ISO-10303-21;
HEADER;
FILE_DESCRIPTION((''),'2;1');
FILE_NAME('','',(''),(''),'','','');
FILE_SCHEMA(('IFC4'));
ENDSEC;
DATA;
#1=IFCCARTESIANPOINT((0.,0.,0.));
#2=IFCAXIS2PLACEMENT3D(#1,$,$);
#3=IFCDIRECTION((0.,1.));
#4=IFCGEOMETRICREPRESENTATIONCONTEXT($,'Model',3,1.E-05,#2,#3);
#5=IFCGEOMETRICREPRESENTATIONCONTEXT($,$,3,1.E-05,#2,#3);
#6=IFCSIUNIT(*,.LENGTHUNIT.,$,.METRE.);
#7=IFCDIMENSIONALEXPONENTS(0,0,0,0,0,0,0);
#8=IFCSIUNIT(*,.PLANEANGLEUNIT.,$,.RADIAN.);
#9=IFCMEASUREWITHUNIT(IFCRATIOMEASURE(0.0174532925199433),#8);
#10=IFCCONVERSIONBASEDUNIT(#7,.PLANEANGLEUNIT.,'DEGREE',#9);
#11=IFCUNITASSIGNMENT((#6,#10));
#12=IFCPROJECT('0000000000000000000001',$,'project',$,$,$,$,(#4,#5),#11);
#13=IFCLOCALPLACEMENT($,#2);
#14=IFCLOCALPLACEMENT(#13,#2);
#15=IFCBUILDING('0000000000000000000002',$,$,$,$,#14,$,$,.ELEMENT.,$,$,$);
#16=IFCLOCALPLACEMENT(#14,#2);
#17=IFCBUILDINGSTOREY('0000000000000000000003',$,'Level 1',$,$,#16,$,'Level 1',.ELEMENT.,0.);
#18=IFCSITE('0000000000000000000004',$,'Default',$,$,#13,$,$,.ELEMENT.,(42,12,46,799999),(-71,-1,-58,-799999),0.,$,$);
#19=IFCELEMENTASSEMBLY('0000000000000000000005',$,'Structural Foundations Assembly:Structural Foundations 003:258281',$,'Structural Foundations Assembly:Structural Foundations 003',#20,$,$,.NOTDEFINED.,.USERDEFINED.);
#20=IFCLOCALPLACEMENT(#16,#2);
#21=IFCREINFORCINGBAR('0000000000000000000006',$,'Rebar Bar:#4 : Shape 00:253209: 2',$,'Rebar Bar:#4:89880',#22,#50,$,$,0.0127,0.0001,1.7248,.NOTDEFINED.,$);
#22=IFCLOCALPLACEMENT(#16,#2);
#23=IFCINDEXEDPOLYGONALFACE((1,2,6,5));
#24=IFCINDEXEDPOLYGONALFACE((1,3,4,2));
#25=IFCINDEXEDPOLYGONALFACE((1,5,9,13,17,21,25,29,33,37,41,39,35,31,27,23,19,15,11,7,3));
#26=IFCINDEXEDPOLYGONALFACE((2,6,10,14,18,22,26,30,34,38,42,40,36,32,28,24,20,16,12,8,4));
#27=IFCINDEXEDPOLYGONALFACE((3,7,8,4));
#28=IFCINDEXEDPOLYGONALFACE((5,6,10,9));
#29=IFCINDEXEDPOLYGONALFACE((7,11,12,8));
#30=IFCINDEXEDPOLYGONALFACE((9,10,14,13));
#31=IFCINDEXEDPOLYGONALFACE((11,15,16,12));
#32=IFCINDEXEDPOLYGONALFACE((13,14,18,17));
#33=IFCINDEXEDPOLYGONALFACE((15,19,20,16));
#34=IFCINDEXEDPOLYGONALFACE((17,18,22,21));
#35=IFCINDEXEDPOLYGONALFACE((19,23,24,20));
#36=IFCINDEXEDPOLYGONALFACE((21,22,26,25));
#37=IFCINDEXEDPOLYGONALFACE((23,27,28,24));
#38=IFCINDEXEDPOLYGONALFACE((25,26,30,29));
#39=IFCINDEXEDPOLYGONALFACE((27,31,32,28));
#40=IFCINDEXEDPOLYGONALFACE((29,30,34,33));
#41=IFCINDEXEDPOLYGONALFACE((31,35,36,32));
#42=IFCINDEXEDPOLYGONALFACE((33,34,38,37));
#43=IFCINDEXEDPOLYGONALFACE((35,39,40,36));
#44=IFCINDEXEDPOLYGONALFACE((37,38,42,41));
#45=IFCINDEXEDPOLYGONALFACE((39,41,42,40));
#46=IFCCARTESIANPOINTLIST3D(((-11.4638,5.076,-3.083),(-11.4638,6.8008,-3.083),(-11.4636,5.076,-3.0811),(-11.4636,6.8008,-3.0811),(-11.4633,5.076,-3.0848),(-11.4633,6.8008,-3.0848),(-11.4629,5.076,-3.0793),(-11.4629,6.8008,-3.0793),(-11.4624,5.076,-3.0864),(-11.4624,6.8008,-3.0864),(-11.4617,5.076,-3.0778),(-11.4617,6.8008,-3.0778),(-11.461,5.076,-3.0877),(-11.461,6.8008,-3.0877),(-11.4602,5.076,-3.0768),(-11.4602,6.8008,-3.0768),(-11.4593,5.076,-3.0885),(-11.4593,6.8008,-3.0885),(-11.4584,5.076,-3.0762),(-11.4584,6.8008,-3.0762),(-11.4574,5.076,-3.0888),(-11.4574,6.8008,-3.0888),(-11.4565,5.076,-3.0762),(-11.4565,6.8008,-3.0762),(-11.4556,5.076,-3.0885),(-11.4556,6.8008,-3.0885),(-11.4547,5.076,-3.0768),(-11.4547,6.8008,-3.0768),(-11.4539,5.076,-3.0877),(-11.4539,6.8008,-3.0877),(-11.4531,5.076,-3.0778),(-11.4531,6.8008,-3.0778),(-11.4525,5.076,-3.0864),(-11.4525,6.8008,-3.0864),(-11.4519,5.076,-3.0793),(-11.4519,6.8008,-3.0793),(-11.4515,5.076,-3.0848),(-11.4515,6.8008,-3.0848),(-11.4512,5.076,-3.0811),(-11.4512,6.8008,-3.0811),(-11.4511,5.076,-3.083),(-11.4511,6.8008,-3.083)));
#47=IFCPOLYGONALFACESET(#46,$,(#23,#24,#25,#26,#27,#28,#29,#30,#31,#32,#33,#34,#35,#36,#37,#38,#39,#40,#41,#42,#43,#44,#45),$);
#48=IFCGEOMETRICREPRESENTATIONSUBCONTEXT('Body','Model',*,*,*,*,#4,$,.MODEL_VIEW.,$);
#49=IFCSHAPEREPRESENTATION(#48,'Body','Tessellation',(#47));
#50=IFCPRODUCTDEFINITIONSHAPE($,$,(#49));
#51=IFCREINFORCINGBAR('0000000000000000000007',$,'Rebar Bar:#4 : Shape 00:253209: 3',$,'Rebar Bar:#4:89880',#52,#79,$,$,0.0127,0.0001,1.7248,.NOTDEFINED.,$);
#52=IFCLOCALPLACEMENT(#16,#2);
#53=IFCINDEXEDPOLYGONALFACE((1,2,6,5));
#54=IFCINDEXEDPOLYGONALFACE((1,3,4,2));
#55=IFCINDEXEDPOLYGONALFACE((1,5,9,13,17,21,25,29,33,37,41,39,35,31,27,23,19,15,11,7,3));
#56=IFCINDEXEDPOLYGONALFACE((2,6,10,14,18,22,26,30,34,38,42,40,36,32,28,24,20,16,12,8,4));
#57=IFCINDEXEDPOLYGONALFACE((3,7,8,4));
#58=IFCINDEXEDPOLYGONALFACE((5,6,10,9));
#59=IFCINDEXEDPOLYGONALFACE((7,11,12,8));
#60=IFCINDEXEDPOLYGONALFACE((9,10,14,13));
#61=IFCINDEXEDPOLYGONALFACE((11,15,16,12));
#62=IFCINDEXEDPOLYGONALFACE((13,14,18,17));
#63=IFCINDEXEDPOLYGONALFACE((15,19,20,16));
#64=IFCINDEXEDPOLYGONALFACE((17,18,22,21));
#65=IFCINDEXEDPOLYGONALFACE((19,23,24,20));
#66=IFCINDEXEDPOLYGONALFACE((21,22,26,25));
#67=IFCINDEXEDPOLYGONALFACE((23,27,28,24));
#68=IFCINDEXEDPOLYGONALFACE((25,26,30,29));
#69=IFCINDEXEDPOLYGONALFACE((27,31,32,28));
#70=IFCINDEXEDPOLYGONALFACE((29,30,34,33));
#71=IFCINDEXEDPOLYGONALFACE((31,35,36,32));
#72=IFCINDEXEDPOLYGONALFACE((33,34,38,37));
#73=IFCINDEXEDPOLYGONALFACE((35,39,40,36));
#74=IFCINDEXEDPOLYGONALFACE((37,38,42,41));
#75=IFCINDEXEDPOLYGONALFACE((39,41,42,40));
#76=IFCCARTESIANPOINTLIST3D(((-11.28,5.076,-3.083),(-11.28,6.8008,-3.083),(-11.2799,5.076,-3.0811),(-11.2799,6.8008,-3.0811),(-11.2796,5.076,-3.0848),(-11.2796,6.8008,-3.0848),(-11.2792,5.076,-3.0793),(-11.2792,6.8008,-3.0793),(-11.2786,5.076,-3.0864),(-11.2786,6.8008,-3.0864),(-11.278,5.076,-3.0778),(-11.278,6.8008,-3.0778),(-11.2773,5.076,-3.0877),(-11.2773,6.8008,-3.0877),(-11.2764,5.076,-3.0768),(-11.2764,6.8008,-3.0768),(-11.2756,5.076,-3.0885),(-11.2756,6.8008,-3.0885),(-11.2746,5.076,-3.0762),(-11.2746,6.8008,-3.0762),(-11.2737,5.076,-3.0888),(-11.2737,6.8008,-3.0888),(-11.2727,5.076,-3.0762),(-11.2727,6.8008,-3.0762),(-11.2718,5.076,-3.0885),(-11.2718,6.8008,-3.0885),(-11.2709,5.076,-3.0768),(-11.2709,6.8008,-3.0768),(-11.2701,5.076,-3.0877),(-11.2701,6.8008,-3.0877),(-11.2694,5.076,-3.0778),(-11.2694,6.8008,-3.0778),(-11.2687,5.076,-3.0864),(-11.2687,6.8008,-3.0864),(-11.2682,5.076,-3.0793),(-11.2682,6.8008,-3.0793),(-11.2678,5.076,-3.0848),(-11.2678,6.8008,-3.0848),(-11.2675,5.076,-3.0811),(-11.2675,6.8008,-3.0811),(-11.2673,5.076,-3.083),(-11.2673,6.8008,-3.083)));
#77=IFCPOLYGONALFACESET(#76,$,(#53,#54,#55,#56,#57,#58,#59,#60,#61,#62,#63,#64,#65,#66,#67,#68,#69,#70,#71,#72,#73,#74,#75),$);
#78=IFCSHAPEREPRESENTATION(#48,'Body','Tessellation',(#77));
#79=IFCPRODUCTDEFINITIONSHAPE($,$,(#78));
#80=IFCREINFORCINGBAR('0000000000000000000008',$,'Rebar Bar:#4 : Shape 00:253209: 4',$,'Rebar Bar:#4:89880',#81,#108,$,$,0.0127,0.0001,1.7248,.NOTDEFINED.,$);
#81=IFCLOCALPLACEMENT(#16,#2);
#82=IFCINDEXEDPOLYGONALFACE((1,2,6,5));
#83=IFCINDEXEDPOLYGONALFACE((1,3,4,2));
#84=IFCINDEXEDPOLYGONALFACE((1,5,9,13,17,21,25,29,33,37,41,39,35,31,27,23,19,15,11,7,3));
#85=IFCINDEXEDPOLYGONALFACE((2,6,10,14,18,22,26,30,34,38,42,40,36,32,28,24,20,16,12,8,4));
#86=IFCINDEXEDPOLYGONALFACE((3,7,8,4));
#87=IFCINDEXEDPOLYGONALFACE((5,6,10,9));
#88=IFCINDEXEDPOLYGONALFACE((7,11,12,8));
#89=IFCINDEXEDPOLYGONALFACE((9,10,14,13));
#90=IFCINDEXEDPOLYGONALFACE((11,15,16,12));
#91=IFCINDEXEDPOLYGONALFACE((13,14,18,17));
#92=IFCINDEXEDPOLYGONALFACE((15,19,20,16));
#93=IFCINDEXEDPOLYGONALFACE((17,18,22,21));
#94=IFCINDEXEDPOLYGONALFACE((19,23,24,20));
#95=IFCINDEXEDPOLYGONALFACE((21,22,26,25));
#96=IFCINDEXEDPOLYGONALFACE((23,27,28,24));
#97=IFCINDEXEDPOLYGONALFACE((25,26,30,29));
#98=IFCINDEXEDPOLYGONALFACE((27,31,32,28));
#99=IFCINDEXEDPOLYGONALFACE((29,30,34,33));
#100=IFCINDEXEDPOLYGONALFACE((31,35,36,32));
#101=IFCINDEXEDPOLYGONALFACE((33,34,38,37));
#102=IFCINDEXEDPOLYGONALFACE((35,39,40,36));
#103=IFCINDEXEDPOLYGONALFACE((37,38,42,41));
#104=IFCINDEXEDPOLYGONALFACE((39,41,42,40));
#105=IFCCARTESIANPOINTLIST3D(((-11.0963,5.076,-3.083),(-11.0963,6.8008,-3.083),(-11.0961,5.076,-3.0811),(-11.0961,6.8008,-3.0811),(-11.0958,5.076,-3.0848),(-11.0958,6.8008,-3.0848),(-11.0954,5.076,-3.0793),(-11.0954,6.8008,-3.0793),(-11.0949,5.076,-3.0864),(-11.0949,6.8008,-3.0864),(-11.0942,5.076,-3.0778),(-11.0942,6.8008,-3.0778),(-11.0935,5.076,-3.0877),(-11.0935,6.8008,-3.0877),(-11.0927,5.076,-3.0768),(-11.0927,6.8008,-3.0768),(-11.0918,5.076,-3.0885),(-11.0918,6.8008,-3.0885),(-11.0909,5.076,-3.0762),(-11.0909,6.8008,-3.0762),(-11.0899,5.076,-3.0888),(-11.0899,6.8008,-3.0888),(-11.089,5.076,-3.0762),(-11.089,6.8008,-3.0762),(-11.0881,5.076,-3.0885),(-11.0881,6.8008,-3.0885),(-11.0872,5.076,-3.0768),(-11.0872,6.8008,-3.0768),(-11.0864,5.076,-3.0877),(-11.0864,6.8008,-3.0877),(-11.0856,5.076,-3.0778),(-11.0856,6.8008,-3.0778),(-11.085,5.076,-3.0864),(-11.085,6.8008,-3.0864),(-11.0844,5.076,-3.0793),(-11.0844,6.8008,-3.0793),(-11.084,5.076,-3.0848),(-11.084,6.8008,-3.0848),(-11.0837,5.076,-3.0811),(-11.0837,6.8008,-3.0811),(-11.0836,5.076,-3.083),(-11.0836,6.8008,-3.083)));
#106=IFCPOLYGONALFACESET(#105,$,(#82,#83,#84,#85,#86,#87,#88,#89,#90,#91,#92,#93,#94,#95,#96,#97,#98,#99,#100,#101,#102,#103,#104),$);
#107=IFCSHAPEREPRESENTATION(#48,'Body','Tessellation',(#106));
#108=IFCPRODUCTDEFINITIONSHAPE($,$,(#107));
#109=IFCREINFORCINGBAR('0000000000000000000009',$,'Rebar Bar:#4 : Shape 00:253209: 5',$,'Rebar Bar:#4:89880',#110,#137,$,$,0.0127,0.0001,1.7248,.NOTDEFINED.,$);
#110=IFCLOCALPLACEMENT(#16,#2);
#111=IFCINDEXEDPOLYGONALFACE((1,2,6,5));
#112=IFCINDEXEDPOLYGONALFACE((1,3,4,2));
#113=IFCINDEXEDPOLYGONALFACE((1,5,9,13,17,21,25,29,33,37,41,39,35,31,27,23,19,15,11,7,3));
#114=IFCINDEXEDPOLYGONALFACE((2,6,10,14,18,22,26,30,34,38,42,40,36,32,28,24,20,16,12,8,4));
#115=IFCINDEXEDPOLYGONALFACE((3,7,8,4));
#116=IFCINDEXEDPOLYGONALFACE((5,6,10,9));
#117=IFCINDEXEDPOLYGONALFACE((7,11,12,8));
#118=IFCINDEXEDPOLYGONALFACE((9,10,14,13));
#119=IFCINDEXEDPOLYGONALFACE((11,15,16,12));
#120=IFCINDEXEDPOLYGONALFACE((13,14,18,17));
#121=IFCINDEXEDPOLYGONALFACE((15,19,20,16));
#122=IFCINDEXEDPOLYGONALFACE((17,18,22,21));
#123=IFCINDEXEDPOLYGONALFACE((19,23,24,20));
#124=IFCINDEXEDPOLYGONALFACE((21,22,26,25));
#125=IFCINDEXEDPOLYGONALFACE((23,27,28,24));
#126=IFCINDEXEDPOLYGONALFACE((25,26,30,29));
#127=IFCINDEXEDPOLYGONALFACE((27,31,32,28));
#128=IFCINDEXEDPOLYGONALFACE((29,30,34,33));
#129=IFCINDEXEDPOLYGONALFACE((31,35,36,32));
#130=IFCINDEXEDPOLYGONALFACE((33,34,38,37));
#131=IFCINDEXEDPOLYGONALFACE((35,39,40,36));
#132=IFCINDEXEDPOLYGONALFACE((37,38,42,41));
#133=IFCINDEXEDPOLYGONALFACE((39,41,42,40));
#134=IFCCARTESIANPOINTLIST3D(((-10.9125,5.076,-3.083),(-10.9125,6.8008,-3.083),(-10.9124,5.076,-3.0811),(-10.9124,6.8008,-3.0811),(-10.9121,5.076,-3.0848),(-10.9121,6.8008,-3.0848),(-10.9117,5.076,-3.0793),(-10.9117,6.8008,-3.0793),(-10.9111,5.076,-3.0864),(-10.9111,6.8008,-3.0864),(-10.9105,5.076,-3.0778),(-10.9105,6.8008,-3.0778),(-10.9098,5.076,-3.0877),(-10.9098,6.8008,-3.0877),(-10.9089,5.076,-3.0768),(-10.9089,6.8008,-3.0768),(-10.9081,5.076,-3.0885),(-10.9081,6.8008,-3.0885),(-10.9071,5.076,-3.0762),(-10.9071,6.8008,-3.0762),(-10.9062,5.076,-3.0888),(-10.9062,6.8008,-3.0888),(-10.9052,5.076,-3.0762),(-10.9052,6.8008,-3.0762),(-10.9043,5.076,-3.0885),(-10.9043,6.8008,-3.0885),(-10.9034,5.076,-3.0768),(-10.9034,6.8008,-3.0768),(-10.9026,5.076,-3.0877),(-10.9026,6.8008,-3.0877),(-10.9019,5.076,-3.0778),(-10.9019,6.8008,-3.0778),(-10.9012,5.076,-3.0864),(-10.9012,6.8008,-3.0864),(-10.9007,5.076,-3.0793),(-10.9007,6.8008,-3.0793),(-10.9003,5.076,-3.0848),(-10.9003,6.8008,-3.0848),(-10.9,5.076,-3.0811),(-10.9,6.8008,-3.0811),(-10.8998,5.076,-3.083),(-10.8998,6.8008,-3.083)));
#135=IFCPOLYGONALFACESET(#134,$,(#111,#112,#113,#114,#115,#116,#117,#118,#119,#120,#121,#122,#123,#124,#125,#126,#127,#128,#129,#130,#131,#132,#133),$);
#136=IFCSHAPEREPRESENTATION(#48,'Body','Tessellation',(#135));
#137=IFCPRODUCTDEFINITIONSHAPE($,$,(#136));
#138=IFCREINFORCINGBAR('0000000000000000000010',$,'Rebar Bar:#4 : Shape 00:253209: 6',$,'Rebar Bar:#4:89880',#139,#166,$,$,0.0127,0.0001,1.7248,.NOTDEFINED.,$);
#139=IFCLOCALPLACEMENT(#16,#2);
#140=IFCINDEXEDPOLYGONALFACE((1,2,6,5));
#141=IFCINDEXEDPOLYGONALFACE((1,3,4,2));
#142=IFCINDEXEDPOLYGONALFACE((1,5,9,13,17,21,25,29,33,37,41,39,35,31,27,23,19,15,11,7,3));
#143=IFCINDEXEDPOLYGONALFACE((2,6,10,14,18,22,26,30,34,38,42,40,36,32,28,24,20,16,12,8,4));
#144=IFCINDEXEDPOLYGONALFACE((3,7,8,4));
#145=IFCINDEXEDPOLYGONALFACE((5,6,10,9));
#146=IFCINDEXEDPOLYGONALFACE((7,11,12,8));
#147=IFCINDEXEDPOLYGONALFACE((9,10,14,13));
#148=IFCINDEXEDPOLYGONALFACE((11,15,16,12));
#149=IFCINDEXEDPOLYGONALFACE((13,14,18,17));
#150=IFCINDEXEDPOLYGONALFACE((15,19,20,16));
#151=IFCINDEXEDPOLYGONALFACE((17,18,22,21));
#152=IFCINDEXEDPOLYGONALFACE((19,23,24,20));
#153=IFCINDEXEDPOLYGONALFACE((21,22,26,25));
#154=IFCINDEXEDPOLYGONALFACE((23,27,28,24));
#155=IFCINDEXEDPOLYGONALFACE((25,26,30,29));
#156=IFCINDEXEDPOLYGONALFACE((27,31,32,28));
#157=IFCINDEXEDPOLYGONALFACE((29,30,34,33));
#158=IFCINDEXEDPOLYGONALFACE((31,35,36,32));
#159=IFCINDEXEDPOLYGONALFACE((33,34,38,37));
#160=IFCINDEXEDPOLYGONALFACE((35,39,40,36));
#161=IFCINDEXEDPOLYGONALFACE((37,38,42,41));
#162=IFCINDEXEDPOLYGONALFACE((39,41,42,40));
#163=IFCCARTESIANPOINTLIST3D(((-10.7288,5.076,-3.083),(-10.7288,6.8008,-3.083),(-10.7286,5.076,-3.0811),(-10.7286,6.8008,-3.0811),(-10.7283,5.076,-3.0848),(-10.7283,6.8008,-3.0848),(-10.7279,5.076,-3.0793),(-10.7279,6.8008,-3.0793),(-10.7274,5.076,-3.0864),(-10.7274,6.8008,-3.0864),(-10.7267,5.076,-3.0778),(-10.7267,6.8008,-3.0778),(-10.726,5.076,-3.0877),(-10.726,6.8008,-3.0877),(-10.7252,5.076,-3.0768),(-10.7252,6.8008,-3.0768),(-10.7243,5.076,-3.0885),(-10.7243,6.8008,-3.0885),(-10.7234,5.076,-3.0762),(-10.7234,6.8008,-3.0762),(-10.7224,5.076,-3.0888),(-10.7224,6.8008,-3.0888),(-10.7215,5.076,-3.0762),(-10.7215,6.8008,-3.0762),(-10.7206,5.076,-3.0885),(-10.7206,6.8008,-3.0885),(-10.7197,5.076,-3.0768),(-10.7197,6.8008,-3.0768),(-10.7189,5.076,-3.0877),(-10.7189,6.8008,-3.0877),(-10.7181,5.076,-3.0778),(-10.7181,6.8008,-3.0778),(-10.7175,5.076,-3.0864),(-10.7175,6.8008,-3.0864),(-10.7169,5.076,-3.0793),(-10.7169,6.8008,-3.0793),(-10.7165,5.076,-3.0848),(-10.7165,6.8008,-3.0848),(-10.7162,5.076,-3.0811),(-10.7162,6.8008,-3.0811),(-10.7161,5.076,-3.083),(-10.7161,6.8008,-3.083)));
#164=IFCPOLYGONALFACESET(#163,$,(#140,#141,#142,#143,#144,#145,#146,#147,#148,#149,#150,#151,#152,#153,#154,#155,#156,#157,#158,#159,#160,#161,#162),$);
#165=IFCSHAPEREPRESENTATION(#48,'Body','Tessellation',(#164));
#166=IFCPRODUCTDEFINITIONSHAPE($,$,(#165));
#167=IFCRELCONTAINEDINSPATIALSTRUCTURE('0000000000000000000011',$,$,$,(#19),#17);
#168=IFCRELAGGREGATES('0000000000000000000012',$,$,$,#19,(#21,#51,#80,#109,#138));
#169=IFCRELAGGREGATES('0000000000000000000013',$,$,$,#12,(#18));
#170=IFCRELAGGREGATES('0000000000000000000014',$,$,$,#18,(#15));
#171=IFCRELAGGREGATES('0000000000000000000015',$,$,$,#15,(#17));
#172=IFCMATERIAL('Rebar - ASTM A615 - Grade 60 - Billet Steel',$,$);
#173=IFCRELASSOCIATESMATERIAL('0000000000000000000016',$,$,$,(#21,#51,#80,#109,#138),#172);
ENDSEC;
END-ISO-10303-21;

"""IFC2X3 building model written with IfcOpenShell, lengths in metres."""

from ifc_helpers import new_model, entity, si_unit, converted_unit, direction, origin, place, context, subcontext, project, spatial, material, element, aggregate, save


model = new_model("IFC2X3")

# Units and contexts
model_context = context("Model", 3, precision=1e-05, world=origin(), true_north=direction((0.0, 1.0)))
context_of_model = context(None, 3, precision=1e-05, world=origin(), true_north=direction((0.0, 1.0)))
body_context = subcontext(model_context, "Body", "Model", "MODEL_VIEW")
ifc_project = project(units=[si_unit("LENGTHUNIT", "METRE"), converted_unit("PLANEANGLEUNIT", "DEGREE", entity("IfcRatioMeasure", 0.0174532925199433), si_unit("PLANEANGLEUNIT", "RADIAN"), dimensions=[0, 0, 0, 0, 0, 0, 0])], contexts=[model_context, context_of_model])

# Site, building, storey
site_placement = place(None, origin())
site = spatial("IfcSite", under=ifc_project, at=site_placement, Name="Default", CompositionType="ELEMENT", RefLatitude=(42, 12, 46, 799999), RefLongitude=(-71, -1, -58, -799999), RefElevation=0.0)
building_placement = place(site_placement, origin())
building = spatial("IfcBuilding", under=site, at=building_placement, CompositionType="ELEMENT")
storey_placement = place(building_placement, origin())
storey = spatial("IfcBuildingStorey", under=building, at=storey_placement, Name="Level 1", LongName="Level 1", CompositionType="ELEMENT", Elevation=0.0)

# Element assembly, reinforcing bars
assembly_1_placement = place(storey_placement, origin())
assembly_1 = element("IfcElementAssembly", 1, at=assembly_1_placement, inside=storey, Name="Structural Foundations Assembly:Structural Foundations 003:258281", ObjectType="Structural Foundations Assembly:Structural Foundations 003", AssemblyPlace="NOTDEFINED", PredefinedType="USERDEFINED")
ifc_material = material(Name="Rebar - ASTM A615 - Grade 60 - Billet Steel")
reinforcing_bar_1_placement = place(assembly_1_placement, origin())
reinforcing_bar_1 = element("IfcReinforcingBar", 2, at=reinforcing_bar_1_placement, material=ifc_material, Name="Rebar Bar:#4 : Shape 00:253209: 2", ObjectType="Rebar Bar:#4:89880", BarLength=1.7248, BarRole="NOTDEFINED", CrossSectionArea=0.0001, NominalDiameter=0.0127, context=body_context, shape_type="AdvancedSweptSolid", body=[
    entity("IfcSweptDiskSolid", entity("IfcCompositeCurve", [entity("IfcCompositeCurveSegment", "CONTINUOUS", True, entity("IfcPolyline", [entity("IfcCartesianPoint", [-11.4574, 6.8008, -3.0825]), entity("IfcCartesianPoint", [-11.4574, 5.076, -3.0825])]))], False), 0.0063, None, 0.0, 1.0),
])
reinforcing_bar_2_placement = place(assembly_1_placement, origin())
reinforcing_bar_2 = element("IfcReinforcingBar", 3, at=reinforcing_bar_2_placement, material=ifc_material, Name="Rebar Bar:#4 : Shape 00:253209: 3", ObjectType="Rebar Bar:#4:89880", BarLength=1.7248, BarRole="NOTDEFINED", CrossSectionArea=0.0001, NominalDiameter=0.0127, context=body_context, shape_type="AdvancedSweptSolid", body=[
    entity("IfcSweptDiskSolid", entity("IfcCompositeCurve", [entity("IfcCompositeCurveSegment", "CONTINUOUS", True, entity("IfcPolyline", [entity("IfcCartesianPoint", [-11.2737, 6.8008, -3.0825]), entity("IfcCartesianPoint", [-11.2737, 5.076, -3.0825])]))], False), 0.0063, None, 0.0, 1.0),
])
reinforcing_bar_3_placement = place(assembly_1_placement, origin())
reinforcing_bar_3 = element("IfcReinforcingBar", 4, at=reinforcing_bar_3_placement, material=ifc_material, Name="Rebar Bar:#4 : Shape 00:253209: 4", ObjectType="Rebar Bar:#4:89880", BarLength=1.7248, BarRole="NOTDEFINED", CrossSectionArea=0.0001, NominalDiameter=0.0127, context=body_context, shape_type="AdvancedSweptSolid", body=[
    entity("IfcSweptDiskSolid", entity("IfcCompositeCurve", [entity("IfcCompositeCurveSegment", "CONTINUOUS", True, entity("IfcPolyline", [entity("IfcCartesianPoint", [-11.0899, 6.8008, -3.0825]), entity("IfcCartesianPoint", [-11.0899, 5.076, -3.0825])]))], False), 0.0063, None, 0.0, 1.0),
])
reinforcing_bar_4_placement = place(assembly_1_placement, origin())
reinforcing_bar_4 = element("IfcReinforcingBar", 5, at=reinforcing_bar_4_placement, material=ifc_material, Name="Rebar Bar:#4 : Shape 00:253209: 5", ObjectType="Rebar Bar:#4:89880", BarLength=1.7248, BarRole="NOTDEFINED", CrossSectionArea=0.0001, NominalDiameter=0.0127, context=body_context, shape_type="AdvancedSweptSolid", body=[
    entity("IfcSweptDiskSolid", entity("IfcCompositeCurve", [entity("IfcCompositeCurveSegment", "CONTINUOUS", True, entity("IfcPolyline", [entity("IfcCartesianPoint", [-10.9062, 6.8008, -3.0825]), entity("IfcCartesianPoint", [-10.9062, 5.076, -3.0825])]))], False), 0.0063, None, 0.0, 1.0),
])
reinforcing_bar_5_placement = place(assembly_1_placement, origin())
reinforcing_bar_5 = element("IfcReinforcingBar", 6, at=reinforcing_bar_5_placement, material=ifc_material, Name="Rebar Bar:#4 : Shape 00:253209: 6", ObjectType="Rebar Bar:#4:89880", BarLength=1.7248, BarRole="NOTDEFINED", CrossSectionArea=0.0001, NominalDiameter=0.0127, context=body_context, shape_type="AdvancedSweptSolid", body=[
    entity("IfcSweptDiskSolid", entity("IfcCompositeCurve", [entity("IfcCompositeCurveSegment", "CONTINUOUS", True, entity("IfcPolyline", [entity("IfcCartesianPoint", [-10.7224, 6.8008, -3.0825]), entity("IfcCartesianPoint", [-10.7224, 5.076, -3.0825])]))], False), 0.0063, None, 0.0, 1.0),
])
aggregate(assembly_1, [reinforcing_bar_1, reinforcing_bar_2, reinforcing_bar_3, reinforcing_bar_4, reinforcing_bar_5])

save(model, "model.ifc")
